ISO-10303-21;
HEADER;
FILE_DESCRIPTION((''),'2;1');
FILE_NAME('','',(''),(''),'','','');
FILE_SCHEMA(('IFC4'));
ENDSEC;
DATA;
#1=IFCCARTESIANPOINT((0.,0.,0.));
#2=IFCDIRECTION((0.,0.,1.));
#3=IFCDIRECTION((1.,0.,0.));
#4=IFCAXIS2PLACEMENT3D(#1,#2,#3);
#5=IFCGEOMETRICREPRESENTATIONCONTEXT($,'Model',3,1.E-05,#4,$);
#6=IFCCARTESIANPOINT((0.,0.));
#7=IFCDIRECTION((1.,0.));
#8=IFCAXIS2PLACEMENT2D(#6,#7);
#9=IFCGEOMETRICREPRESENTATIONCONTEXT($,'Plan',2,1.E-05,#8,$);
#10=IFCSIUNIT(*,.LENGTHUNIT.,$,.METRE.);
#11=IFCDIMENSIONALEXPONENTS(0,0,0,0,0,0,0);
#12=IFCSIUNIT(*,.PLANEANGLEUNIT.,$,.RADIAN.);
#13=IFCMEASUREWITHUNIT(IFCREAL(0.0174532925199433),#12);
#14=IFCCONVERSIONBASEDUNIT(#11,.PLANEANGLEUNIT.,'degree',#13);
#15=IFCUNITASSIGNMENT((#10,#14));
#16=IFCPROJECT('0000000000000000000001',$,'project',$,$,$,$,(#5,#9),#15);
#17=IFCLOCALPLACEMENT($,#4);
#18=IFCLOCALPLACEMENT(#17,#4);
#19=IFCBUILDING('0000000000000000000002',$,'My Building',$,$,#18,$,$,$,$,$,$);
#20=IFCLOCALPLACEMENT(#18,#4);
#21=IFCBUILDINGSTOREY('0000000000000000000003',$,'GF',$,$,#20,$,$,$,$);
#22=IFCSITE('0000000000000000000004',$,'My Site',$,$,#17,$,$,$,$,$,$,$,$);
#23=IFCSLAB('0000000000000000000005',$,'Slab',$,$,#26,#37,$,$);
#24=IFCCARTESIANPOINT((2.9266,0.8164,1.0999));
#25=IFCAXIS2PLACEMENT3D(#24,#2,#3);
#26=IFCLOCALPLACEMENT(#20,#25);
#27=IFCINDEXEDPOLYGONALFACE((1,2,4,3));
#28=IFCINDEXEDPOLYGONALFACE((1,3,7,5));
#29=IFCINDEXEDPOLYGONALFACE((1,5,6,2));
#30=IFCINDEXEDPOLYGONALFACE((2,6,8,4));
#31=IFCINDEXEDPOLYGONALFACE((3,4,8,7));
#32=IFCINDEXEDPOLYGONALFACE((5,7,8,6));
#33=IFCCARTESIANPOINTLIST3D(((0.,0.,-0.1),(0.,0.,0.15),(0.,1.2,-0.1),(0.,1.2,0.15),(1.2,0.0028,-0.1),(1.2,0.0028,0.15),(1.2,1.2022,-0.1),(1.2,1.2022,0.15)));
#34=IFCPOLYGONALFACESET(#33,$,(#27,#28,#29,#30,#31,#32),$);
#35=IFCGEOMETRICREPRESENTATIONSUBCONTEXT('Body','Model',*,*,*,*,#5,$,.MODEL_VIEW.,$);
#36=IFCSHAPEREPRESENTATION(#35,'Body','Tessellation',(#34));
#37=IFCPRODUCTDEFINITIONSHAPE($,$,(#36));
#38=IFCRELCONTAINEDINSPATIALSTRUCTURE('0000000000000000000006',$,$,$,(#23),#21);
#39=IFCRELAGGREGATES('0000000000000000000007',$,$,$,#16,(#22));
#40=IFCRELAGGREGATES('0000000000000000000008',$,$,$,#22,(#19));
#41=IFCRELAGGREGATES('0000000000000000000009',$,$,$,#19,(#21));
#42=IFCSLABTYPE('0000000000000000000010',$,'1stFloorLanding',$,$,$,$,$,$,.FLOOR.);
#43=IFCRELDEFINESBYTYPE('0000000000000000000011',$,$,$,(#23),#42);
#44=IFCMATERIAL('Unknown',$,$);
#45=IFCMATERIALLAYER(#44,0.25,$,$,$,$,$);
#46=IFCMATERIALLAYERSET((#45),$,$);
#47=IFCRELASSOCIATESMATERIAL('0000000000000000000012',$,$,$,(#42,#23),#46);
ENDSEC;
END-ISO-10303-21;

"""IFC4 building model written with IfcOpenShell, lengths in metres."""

from ifc_helpers import new_model, entity, si_unit, converted_unit, frame, origin_with_axes, origin_2d_with_axis, place, context, subcontext, project, spatial, indexed_curve, outline, extrude, material, layer, layer_set, layer_usage, type_object, element, save


model = new_model("IFC4")

# Units and contexts
model_context = context("Model", 3, precision=1e-05, world=origin_with_axes())
plan_context = context("Plan", 2, precision=1e-05, world=origin_2d_with_axis())
body_context_1 = subcontext(model_context, "Body", "Model", "MODEL_VIEW")
ifc_project = project(units=[si_unit("LENGTHUNIT", "METRE"), converted_unit("PLANEANGLEUNIT", "degree", entity("IfcReal", 0.0174532925199433), si_unit("PLANEANGLEUNIT", "RADIAN"), dimensions=[0, 0, 0, 0, 0, 0, 0])], contexts=[model_context, plan_context])

# Site, building, storey
site_placement = place(None, origin_with_axes())
site = spatial("IfcSite", under=ifc_project, at=site_placement, Name="My Site")
building_placement = place(site_placement, origin_with_axes())
building = spatial("IfcBuilding", under=site, at=building_placement, Name="My Building")
storey_placement = place(building_placement, origin_with_axes())
storey = spatial("IfcBuildingStorey", under=building, at=storey_placement, Name="GF")

# Slab
ifc_material = material(Name="Unknown")
ifc_layer_1 = layer(ifc_material, 0.25)
ifc_layer_set_1 = layer_set([ifc_layer_1])
ifc_layer_usage_1 = layer_usage(ifc_layer_set_1, "AXIS3", "POSITIVE", -0.1)
slab_type_1 = type_object("IfcSlabType", Name="1stFloorLanding", PredefinedType="FLOOR", material=ifc_layer_set_1)
slab_1_placement = place(storey_placement, frame((2.9266, 0.8164, 1.0999), z_axis=(0.0, 0.0, 1.0), x_axis=(1.0, 0.0, 0.0)))
element("IfcSlab", 1, at=slab_1_placement, inside=storey, type_object=slab_type_1, material=ifc_layer_usage_1, Name="Slab", context=body_context_1, shape_type="SweptSolid", body=[
    extrude(outline(indexed_curve([(0.0, 0.0), (0.0, 1.2), (1.2, 1.2022), (1.2, 0.0028), (0.0, 0.0)])), frame((0.0, 0.0, -0.1), z_axis=(0.0, 0.0, 1.0), x_axis=(1.0, 0.0, 0.0)), (0.0, 0.0, 1.0), 0.25),
])

save(model, "model.ifc")
